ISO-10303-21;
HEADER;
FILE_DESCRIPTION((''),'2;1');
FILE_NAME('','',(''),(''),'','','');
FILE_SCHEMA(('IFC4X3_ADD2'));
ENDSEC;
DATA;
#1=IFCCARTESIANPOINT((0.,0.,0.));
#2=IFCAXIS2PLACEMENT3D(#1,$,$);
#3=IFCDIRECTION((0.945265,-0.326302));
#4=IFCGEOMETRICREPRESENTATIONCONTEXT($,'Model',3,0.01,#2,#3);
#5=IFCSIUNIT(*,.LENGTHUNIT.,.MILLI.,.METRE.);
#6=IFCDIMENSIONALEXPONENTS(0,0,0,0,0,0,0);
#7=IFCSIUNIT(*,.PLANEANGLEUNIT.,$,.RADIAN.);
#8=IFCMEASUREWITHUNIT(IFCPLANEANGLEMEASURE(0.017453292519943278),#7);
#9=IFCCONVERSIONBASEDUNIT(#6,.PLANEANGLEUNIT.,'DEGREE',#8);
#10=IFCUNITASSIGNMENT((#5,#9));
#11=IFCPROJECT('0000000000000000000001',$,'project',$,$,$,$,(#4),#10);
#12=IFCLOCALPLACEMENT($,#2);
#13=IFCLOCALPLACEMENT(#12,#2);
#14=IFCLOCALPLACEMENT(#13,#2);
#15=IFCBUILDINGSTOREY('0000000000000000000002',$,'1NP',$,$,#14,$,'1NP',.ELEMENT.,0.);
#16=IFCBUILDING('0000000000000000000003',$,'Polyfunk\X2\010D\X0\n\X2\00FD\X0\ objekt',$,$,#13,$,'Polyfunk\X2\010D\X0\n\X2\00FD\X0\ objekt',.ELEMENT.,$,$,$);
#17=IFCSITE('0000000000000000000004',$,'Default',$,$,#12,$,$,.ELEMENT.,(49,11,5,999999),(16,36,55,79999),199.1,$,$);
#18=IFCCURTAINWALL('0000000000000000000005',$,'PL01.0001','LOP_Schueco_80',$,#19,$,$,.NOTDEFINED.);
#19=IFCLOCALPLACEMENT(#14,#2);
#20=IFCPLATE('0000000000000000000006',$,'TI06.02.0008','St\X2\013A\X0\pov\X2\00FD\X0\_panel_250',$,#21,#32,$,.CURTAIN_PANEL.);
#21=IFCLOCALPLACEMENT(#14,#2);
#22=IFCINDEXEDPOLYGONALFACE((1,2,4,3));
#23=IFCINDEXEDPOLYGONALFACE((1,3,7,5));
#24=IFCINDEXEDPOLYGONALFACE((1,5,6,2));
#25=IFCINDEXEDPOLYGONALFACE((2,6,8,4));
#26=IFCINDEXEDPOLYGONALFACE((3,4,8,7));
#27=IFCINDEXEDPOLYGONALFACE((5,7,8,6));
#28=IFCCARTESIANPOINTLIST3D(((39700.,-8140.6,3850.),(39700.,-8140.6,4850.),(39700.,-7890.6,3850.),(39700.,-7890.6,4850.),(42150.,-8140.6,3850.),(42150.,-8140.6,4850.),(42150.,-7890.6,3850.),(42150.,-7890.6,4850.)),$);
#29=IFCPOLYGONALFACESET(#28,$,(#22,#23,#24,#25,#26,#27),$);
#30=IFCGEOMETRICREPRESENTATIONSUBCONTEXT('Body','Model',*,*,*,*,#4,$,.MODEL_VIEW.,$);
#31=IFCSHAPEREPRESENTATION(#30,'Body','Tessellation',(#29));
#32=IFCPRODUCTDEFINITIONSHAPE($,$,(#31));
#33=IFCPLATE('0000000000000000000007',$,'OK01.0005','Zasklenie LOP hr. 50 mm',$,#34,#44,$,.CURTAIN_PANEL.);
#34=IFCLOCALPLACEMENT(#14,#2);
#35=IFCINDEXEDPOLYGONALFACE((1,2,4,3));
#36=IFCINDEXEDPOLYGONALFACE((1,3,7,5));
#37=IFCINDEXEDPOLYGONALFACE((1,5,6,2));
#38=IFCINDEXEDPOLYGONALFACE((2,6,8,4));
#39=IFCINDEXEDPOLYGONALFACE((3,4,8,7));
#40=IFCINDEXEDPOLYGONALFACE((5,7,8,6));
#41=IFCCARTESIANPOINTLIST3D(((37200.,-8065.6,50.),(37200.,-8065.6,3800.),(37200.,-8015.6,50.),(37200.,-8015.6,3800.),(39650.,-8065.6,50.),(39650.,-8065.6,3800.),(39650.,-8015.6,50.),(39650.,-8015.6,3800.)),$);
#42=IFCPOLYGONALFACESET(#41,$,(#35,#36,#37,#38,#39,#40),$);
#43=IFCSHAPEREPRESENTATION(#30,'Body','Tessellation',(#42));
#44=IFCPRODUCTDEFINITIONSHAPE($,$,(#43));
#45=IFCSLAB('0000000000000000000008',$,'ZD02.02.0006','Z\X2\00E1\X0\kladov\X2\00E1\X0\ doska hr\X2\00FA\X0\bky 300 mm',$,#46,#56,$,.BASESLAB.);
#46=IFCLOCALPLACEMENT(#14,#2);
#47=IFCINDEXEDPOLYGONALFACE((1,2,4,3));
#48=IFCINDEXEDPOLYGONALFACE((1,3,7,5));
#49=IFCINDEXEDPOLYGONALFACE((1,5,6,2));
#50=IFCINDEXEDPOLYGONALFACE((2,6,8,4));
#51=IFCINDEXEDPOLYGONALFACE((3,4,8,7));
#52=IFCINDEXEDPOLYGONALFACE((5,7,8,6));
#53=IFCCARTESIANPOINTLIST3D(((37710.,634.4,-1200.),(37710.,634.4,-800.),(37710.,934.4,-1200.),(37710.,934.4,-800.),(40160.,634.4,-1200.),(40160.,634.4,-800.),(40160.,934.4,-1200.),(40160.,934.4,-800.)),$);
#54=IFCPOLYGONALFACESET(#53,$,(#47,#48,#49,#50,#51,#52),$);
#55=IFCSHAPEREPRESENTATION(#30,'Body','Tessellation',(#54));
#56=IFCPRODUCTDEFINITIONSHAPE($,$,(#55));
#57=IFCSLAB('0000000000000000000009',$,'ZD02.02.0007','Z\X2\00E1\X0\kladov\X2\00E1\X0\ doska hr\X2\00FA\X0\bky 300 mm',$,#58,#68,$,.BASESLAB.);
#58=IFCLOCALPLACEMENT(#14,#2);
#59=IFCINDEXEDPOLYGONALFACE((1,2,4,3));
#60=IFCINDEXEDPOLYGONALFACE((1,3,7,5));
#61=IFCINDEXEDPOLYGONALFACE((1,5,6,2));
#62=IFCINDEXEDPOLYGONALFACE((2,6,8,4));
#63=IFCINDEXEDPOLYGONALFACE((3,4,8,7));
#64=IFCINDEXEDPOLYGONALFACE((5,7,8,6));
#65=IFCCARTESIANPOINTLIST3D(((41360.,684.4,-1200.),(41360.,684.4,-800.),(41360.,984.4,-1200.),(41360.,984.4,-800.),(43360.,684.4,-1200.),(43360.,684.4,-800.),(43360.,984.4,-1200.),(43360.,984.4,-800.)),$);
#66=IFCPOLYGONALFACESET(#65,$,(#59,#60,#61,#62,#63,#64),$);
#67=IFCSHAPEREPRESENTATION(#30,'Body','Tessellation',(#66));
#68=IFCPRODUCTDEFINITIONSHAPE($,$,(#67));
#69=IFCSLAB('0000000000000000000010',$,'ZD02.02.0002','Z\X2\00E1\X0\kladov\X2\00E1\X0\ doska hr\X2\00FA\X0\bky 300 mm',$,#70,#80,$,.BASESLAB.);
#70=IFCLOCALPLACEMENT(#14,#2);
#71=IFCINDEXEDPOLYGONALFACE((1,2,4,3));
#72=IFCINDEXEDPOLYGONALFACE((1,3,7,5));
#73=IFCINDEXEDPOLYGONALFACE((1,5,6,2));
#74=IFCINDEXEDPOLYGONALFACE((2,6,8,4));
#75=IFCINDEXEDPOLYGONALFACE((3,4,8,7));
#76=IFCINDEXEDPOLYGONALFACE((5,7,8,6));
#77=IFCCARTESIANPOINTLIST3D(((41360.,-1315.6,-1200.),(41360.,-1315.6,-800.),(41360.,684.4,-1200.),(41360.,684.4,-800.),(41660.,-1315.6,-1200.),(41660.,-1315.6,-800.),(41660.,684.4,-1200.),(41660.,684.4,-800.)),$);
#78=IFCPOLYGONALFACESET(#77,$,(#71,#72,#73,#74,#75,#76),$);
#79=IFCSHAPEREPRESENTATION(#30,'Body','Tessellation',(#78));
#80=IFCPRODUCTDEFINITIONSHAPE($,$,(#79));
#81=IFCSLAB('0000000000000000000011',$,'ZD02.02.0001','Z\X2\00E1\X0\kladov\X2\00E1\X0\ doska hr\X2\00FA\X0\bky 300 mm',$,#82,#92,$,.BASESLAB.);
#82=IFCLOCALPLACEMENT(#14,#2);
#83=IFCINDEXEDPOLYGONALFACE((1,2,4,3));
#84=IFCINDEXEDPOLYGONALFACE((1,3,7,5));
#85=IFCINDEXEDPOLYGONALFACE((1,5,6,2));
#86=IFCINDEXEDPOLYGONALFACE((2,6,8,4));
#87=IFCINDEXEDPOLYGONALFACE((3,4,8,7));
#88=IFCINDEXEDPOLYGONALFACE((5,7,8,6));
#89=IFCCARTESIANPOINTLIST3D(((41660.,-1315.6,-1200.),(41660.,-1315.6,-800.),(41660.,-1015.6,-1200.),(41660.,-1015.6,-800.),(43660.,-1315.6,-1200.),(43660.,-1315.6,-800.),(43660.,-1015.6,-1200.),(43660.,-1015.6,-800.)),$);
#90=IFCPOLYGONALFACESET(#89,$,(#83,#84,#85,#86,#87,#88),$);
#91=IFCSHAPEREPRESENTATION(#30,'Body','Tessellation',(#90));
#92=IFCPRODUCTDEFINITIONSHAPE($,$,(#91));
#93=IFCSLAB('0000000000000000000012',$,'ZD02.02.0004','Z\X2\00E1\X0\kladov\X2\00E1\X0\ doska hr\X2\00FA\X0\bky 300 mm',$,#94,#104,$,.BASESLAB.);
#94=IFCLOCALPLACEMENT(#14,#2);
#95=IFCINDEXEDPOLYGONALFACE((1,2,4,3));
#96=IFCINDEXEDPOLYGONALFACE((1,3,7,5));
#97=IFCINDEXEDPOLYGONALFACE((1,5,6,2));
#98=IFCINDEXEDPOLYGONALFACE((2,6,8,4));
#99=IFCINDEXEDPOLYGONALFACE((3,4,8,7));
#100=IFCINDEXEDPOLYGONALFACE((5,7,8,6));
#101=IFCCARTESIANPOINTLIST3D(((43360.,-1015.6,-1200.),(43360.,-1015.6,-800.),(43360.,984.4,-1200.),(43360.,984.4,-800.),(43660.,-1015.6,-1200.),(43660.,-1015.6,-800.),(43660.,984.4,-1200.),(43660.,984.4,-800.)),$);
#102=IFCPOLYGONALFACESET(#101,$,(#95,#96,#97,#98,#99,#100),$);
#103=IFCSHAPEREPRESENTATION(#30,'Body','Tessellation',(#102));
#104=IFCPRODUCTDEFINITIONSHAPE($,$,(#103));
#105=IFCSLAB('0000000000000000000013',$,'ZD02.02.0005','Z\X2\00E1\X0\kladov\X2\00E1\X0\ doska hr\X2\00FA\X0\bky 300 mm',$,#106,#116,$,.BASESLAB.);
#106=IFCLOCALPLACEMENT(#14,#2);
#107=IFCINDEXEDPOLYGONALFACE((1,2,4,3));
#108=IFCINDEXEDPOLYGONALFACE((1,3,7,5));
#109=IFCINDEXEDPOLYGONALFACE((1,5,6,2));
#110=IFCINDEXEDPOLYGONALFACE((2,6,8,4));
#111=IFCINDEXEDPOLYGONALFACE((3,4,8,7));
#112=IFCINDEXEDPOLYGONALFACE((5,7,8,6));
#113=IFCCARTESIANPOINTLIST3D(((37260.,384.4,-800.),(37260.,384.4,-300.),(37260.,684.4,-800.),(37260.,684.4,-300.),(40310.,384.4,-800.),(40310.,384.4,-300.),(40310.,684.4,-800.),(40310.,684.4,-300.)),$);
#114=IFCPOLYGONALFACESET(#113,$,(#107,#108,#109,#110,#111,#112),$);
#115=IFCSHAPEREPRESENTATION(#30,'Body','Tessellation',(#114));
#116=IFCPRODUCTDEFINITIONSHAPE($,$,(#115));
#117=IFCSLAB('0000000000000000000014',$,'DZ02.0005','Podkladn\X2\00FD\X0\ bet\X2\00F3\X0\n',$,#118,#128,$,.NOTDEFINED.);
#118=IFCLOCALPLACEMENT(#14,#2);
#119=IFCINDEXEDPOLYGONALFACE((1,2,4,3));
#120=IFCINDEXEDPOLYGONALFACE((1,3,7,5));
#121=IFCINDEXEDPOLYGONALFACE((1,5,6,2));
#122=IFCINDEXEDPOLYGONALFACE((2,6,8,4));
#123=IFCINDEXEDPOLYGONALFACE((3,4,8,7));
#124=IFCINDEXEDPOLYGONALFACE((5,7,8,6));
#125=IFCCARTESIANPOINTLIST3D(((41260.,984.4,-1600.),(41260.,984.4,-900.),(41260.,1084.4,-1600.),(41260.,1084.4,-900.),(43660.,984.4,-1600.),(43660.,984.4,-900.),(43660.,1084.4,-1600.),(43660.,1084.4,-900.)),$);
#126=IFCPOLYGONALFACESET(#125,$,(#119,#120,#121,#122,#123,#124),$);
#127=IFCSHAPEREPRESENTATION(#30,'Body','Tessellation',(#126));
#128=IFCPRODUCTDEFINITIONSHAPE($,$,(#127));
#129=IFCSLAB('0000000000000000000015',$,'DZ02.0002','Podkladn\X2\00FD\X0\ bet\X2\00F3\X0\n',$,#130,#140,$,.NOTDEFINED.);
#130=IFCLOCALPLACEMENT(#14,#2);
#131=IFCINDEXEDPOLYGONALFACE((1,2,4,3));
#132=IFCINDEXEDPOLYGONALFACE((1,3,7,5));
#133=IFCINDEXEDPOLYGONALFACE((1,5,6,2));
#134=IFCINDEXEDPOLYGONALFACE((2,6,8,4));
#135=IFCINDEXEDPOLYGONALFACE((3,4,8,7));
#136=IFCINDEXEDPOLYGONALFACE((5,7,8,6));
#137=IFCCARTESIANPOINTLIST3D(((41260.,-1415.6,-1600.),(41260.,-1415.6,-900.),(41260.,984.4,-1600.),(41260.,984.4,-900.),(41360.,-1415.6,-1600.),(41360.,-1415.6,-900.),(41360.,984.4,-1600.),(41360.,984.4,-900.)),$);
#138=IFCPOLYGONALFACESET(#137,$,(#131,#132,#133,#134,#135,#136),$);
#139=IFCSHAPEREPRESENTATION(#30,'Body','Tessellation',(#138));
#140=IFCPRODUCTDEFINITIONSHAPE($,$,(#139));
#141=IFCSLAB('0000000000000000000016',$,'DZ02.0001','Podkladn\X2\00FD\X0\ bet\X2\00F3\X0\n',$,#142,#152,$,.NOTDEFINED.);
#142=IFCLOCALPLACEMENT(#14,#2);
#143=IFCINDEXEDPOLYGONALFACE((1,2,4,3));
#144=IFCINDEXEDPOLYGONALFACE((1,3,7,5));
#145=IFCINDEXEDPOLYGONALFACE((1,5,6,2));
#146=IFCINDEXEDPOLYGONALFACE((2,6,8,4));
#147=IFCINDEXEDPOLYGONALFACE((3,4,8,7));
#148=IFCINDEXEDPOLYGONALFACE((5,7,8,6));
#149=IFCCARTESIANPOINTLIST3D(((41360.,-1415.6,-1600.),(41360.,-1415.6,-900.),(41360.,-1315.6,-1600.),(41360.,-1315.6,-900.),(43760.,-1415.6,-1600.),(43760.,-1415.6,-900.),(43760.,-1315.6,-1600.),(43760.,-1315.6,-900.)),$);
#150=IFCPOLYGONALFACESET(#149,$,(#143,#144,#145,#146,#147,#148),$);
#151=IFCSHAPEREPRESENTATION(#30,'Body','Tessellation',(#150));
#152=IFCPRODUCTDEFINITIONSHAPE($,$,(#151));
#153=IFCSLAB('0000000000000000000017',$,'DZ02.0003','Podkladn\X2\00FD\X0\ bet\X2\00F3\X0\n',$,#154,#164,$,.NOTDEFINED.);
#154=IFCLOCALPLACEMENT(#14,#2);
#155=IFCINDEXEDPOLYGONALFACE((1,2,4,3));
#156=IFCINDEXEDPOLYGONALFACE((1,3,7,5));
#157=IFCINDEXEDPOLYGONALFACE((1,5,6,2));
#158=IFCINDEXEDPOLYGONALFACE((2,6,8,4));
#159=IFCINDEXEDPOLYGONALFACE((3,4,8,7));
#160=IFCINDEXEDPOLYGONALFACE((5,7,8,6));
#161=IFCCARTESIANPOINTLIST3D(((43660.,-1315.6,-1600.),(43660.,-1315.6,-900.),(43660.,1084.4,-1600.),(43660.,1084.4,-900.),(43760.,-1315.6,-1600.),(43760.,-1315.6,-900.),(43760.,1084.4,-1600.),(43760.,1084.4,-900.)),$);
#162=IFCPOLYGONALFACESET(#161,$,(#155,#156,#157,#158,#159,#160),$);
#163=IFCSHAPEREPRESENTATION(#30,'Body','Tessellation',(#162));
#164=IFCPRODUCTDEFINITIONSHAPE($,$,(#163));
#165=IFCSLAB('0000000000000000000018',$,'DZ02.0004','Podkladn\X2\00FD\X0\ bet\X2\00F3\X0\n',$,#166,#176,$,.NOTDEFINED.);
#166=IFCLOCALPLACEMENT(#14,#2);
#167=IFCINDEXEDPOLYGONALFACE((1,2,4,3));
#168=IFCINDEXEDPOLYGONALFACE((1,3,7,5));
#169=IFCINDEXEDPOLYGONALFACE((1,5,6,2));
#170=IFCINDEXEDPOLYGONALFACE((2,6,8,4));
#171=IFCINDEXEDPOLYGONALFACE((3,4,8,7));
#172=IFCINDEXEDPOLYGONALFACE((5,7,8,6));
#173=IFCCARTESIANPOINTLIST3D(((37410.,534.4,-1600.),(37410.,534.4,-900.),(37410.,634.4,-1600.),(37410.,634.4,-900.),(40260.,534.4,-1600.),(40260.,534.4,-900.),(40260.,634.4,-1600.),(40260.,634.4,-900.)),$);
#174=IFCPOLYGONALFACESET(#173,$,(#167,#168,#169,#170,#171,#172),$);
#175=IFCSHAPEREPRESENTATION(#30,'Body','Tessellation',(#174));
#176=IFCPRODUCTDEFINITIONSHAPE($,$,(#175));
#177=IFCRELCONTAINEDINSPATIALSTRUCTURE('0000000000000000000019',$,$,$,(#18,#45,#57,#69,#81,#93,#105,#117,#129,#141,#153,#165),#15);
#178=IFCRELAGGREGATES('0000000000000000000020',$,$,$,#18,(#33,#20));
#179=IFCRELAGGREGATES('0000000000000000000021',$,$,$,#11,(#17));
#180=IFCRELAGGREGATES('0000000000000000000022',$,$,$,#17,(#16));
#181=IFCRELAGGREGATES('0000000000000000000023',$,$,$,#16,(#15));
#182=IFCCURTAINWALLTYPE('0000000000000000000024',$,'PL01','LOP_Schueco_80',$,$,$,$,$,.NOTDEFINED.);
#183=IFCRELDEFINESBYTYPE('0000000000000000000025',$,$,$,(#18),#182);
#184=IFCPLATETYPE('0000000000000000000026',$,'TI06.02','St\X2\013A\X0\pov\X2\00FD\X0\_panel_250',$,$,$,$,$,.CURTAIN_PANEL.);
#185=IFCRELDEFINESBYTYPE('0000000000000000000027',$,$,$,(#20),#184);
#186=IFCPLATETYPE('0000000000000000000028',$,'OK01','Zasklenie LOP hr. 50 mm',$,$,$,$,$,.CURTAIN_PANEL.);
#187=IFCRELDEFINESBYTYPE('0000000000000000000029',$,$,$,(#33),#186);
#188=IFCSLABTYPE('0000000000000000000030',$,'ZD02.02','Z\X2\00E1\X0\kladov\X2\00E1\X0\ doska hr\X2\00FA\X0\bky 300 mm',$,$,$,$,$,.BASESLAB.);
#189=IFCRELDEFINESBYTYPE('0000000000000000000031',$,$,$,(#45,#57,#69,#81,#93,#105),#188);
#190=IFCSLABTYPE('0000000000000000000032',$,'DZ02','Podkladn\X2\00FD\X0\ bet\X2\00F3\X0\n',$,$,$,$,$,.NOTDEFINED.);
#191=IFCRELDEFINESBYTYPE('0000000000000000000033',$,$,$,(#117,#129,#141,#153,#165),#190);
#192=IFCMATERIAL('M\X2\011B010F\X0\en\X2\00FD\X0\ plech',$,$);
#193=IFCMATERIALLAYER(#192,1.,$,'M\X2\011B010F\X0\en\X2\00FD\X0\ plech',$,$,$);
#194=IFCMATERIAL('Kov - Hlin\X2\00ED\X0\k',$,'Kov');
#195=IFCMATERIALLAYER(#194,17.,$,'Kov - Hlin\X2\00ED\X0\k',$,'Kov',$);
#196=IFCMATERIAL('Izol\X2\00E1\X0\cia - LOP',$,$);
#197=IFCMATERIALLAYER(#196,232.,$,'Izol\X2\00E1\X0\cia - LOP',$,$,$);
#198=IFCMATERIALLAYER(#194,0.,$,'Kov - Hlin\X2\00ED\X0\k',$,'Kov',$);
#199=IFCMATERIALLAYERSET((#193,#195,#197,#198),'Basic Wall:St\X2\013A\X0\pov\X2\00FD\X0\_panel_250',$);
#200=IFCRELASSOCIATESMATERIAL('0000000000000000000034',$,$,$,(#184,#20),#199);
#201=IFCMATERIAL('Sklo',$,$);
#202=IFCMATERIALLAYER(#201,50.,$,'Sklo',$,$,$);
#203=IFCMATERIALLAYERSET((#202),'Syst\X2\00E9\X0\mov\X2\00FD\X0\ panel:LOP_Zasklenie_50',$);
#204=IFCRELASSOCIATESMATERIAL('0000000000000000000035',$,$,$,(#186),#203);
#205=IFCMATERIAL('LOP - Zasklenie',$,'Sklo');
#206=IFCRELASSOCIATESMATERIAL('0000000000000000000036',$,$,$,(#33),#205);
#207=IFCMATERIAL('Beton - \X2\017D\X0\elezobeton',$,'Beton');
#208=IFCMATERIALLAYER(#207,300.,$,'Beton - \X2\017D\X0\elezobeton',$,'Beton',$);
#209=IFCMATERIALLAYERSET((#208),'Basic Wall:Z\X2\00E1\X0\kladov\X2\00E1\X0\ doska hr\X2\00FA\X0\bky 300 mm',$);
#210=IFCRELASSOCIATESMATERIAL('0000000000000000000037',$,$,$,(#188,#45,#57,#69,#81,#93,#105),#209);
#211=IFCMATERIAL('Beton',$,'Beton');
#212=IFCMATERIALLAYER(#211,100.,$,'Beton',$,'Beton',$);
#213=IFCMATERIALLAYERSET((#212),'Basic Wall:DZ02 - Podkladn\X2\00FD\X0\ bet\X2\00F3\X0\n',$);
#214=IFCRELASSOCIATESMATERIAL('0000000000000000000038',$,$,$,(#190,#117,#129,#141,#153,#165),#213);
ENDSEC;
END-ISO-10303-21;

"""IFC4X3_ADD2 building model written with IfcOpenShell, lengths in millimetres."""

from ifc_helpers import new_model, entity, si_unit, converted_unit, direction, frame, frame_2d, origin, place, context, subcontext, project, spatial, rectangle, extrude, source, transform, mapped, material, layer, layer_set, layer_usage, type_object, type_shapes, element, aggregate, save


model = new_model("IFC4X3_ADD2")

# Units and contexts
model_context = context("Model", 3, precision=0.01, world=origin(), true_north=direction((0.945265, -0.326302)))
body_context = subcontext(model_context, "Body", "Model", "MODEL_VIEW")
ifc_project = project(units=[si_unit("LENGTHUNIT", "METRE", prefix="MILLI"), converted_unit("PLANEANGLEUNIT", "DEGREE", entity("IfcPlaneAngleMeasure", 0.017453292519943278), si_unit("PLANEANGLEUNIT", "RADIAN"), dimensions=[0, 0, 0, 0, 0, 0, 0])], contexts=[model_context])

# Site, building, storey
site_placement = place(None, origin())
site = spatial("IfcSite", under=ifc_project, at=site_placement, Name="Default", CompositionType="ELEMENT", RefLatitude=(49, 11, 5, 999999), RefLongitude=(16, 36, 55, 79999), RefElevation=199.1)
building_placement = place(site_placement, origin())
building = spatial("IfcBuilding", under=site, at=building_placement, Name="Polyfunkčný objekt", LongName="Polyfunkčný objekt", CompositionType="ELEMENT")
storey_placement = place(building_placement, origin())
storey = spatial("IfcBuildingStorey", under=building, at=storey_placement, Name="1NP", LongName="1NP", CompositionType="ELEMENT", Elevation=0.0)

# Curtain wall, plates
curtain_wall_type = type_object("IfcCurtainWallType", Name="PL01", Description="LOP_Schueco_80", PredefinedType="NOTDEFINED")
curtain_wall_placement = place(storey_placement, origin())
curtain_wall = element("IfcCurtainWall", 1, at=curtain_wall_placement, inside=storey, type_object=curtain_wall_type, Name="PL01.0001", Description="LOP_Schueco_80", PredefinedType="NOTDEFINED")
ifc_material_1 = material(Name="Měďený plech")
ifc_layer_1 = layer(ifc_material_1, 1.0, Name="Měďený plech")
ifc_material_2 = material(Name="Kov - Hliník", Category="Kov")
ifc_layer_2 = layer(ifc_material_2, 17.0, Name="Kov - Hliník", Category="Kov")
ifc_material_3 = material(Name="Izolácia - LOP")
ifc_layer_3 = layer(ifc_material_3, 232.0, Name="Izolácia - LOP")
ifc_layer_4 = layer(ifc_material_2, 0.0, Name="Kov - Hliník", Category="Kov")
ifc_layer_set_1 = layer_set([ifc_layer_1, ifc_layer_2, ifc_layer_3, ifc_layer_4], Name="Basic Wall:Stĺpový_panel_250")
ifc_layer_usage = layer_usage(ifc_layer_set_1, "AXIS2", "POSITIVE", -125.0)
plate_type_1 = type_object("IfcPlateType", Name="TI06.02", Description="Stĺpový_panel_250", PredefinedType="CURTAIN_PANEL", material=ifc_layer_set_1)
plate_1_placement = place(storey_placement, frame((39700.0, -8015.6, 3850.0)))
plate_1 = element("IfcPlate", 2, at=plate_1_placement, type_object=plate_type_1, material=ifc_layer_usage, Name="TI06.02.0008", Description="Stĺpový_panel_250", PredefinedType="CURTAIN_PANEL", context=body_context, shape_type="SweptSolid", body=[
    extrude(rectangle(XDim=250.0, YDim=2450.0, at=frame_2d((0.0, 0.0), x_axis=(1.0, 0.0))), frame((1225.0, 0.0, 0.0), z_axis=(0.0, 0.0, 1.0), x_axis=(0.0, 1.0, 0.0)), (0.0, 0.0, 1.0), 1000.0),
])
ifc_material_4 = material(Name="LOP - Zasklenie", Category="Sklo")
ifc_material_5 = material(Name="Sklo")
ifc_layer_5 = layer(ifc_material_5, 50.0, Name="Sklo")
ifc_layer_set_2 = layer_set([ifc_layer_5], Name="Systémový panel:LOP_Zasklenie_50")
plate_type_2 = type_object("IfcPlateType", Name="OK01", Description="Zasklenie LOP hr. 50 mm", PredefinedType="CURTAIN_PANEL", material=ifc_layer_set_2)
shared_shape_1 = source(origin(), body_context, "Body", "SweptSolid", [
    extrude(rectangle(XDim=3750.0, YDim=2450.0, at=frame_2d((-331.2, 0.0), x_axis=(1.0, 0.0))), frame((0.0, -50.0, 2206.2), z_axis=(0.0, 1.0, 0.0), x_axis=(0.0, 0.0, 1.0)), (0.0, 0.0, 1.0), 50.0),
])
type_shapes(plate_type_2, [shared_shape_1])
plate_2_placement = place(curtain_wall_placement, frame((38425.0, -8015.6, 50.0)))
plate_2 = element("IfcPlate", 3, at=plate_2_placement, type_object=plate_type_2, material=ifc_material_4, Name="OK01.0005", Description="Zasklenie LOP hr. 50 mm", PredefinedType="CURTAIN_PANEL", context=body_context, shape_type="MappedRepresentation", body=[
    mapped(shared_shape_1, transform((0.0, 0.0, 0.0), scale=1.0)),
])
aggregate(curtain_wall, [plate_2, plate_1])

# Slabs
ifc_material_6 = material(Name="Beton - Železobeton", Category="Beton")
ifc_layer_6 = layer(ifc_material_6, 300.0, Name="Beton - Železobeton", Category="Beton")
ifc_layer_set_3 = layer_set([ifc_layer_6], Name="Basic Wall:Základová doska hrúbky 300 mm")
slab_type_1 = type_object("IfcSlabType", Name="ZD02.02", Description="Základová doska hrúbky 300 mm", PredefinedType="BASESLAB", material=ifc_layer_set_3)
slab_1_placement = place(storey_placement, frame((40160.0, 784.4, -1200.0), z_axis=(0.0, 0.0, 1.0), x_axis=(-1.0, 0.0, 0.0)))
element("IfcSlab", 4, at=slab_1_placement, inside=storey, type_object=slab_type_1, material=ifc_layer_set_3, Name="ZD02.02.0006", Description="Základová doska hrúbky 300 mm", PredefinedType="BASESLAB", context=body_context, shape_type="SweptSolid", body=[
    extrude(rectangle(XDim=2450.0, YDim=300.0, at=frame_2d((1225.0, 0.0), x_axis=(-1.0, 0.0))), origin(), (0.0, 0.0, 1.0), 400.0),
])
slab_2_placement = place(storey_placement, frame((41360.0, 834.4, -1200.0)))
element("IfcSlab", 5, at=slab_2_placement, inside=storey, type_object=slab_type_1, material=ifc_layer_set_3, Name="ZD02.02.0007", Description="Základová doska hrúbky 300 mm", PredefinedType="BASESLAB", context=body_context, shape_type="SweptSolid", body=[
    extrude(rectangle(XDim=2000.0, YDim=300.0, at=frame_2d((1000.0, 0.0), x_axis=(-1.0, 0.0))), origin(), (0.0, 0.0, 1.0), 400.0),
])
slab_3_placement = place(storey_placement, frame((41510.0, -1315.6, -1200.0), z_axis=(0.0, 0.0, 1.0), x_axis=(0.0, 1.0, 0.0)))
element("IfcSlab", 6, at=slab_3_placement, inside=storey, type_object=slab_type_1, material=ifc_layer_set_3, Name="ZD02.02.0002", Description="Základová doska hrúbky 300 mm", PredefinedType="BASESLAB", context=body_context, shape_type="SweptSolid", body=[
    extrude(rectangle(XDim=2000.0, YDim=300.0, at=frame_2d((1000.0, 0.0), x_axis=(-1.0, 0.0))), origin(), (0.0, 0.0, 1.0), 400.0),
])
slab_4_placement = place(storey_placement, frame((43660.0, -1165.6, -1200.0), z_axis=(0.0, 0.0, 1.0), x_axis=(-1.0, 0.0, 0.0)))
element("IfcSlab", 7, at=slab_4_placement, inside=storey, type_object=slab_type_1, material=ifc_layer_set_3, Name="ZD02.02.0001", Description="Základová doska hrúbky 300 mm", PredefinedType="BASESLAB", context=body_context, shape_type="SweptSolid", body=[
    extrude(rectangle(XDim=2000.0, YDim=300.0, at=frame_2d((1000.0, 0.0), x_axis=(-1.0, 0.0))), origin(), (0.0, 0.0, 1.0), 400.0),
])
slab_5_placement = place(storey_placement, frame((43510.0, 984.4, -1200.0), z_axis=(0.0, 0.0, 1.0), x_axis=(0.0, -1.0, 0.0)))
element("IfcSlab", 8, at=slab_5_placement, inside=storey, type_object=slab_type_1, material=ifc_layer_set_3, Name="ZD02.02.0004", Description="Základová doska hrúbky 300 mm", PredefinedType="BASESLAB", context=body_context, shape_type="SweptSolid", body=[
    extrude(rectangle(XDim=2000.0, YDim=300.0, at=frame_2d((1000.0, 0.0), x_axis=(-1.0, 0.0))), origin(), (0.0, 0.0, 1.0), 400.0),
])
slab_6_placement = place(storey_placement, frame((40310.0, 534.4, -800.0), z_axis=(0.0, 0.0, 1.0), x_axis=(-1.0, 0.0, 0.0)))
element("IfcSlab", 9, at=slab_6_placement, inside=storey, type_object=slab_type_1, material=ifc_layer_set_3, Name="ZD02.02.0005", Description="Základová doska hrúbky 300 mm", PredefinedType="BASESLAB", context=body_context, shape_type="SweptSolid", body=[
    extrude(rectangle(XDim=3050.0, YDim=300.0, at=frame_2d((1525.0, 0.0), x_axis=(-1.0, 0.0))), origin(), (0.0, 0.0, 1.0), 500.0),
])
ifc_material_7 = material(Name="Beton", Category="Beton")
ifc_layer_7 = layer(ifc_material_7, 100.0, Name="Beton", Category="Beton")
ifc_layer_set_4 = layer_set([ifc_layer_7], Name="Basic Wall:DZ02 - Podkladný betón")
slab_type_2 = type_object("IfcSlabType", Name="DZ02", Description="Podkladný betón", PredefinedType="NOTDEFINED", material=ifc_layer_set_4)
slab_7_placement = place(storey_placement, frame((41260.0, 1034.4, -1600.0)))
element("IfcSlab", 10, at=slab_7_placement, inside=storey, type_object=slab_type_2, material=ifc_layer_set_4, Name="DZ02.0005", Description="Podkladný betón", PredefinedType="NOTDEFINED", context=body_context, shape_type="SweptSolid", body=[
    extrude(rectangle(XDim=2400.0, YDim=100.0, at=frame_2d((1200.0, 0.0), x_axis=(-1.0, 0.0))), origin(), (0.0, 0.0, 1.0), 700.0),
])
slab_8_placement = place(storey_placement, frame((41310.0, -1415.6, -1600.0), z_axis=(0.0, 0.0, 1.0), x_axis=(0.0, 1.0, 0.0)))
element("IfcSlab", 11, at=slab_8_placement, inside=storey, type_object=slab_type_2, material=ifc_layer_set_4, Name="DZ02.0002", Description="Podkladný betón", PredefinedType="NOTDEFINED", context=body_context, shape_type="SweptSolid", body=[
    extrude(rectangle(XDim=2400.0, YDim=100.0, at=frame_2d((1200.0, 0.0), x_axis=(-1.0, 0.0))), origin(), (0.0, 0.0, 1.0), 700.0),
])
slab_9_placement = place(storey_placement, frame((43760.0, -1365.6, -1600.0), z_axis=(0.0, 0.0, 1.0), x_axis=(-1.0, 0.0, 0.0)))
element("IfcSlab", 12, at=slab_9_placement, inside=storey, type_object=slab_type_2, material=ifc_layer_set_4, Name="DZ02.0001", Description="Podkladný betón", PredefinedType="NOTDEFINED", context=body_context, shape_type="SweptSolid", body=[
    extrude(rectangle(XDim=2400.0, YDim=100.0, at=frame_2d((1200.0, 0.0), x_axis=(-1.0, 0.0))), origin(), (0.0, 0.0, 1.0), 700.0),
])
slab_10_placement = place(storey_placement, frame((43710.0, 1084.4, -1600.0), z_axis=(0.0, 0.0, 1.0), x_axis=(0.0, -1.0, 0.0)))
element("IfcSlab", 13, at=slab_10_placement, inside=storey, type_object=slab_type_2, material=ifc_layer_set_4, Name="DZ02.0003", Description="Podkladný betón", PredefinedType="NOTDEFINED", context=body_context, shape_type="SweptSolid", body=[
    extrude(rectangle(XDim=2400.0, YDim=100.0, at=frame_2d((1200.0, 0.0), x_axis=(-1.0, 0.0))), origin(), (0.0, 0.0, 1.0), 700.0),
])
slab_11_placement = place(storey_placement, frame((40260.0, 584.4, -1600.0), z_axis=(0.0, 0.0, 1.0), x_axis=(-1.0, 0.0, 0.0)))
element("IfcSlab", 14, at=slab_11_placement, inside=storey, type_object=slab_type_2, material=ifc_layer_set_4, Name="DZ02.0004", Description="Podkladný betón", PredefinedType="NOTDEFINED", context=body_context, shape_type="SweptSolid", body=[
    extrude(rectangle(XDim=2850.0, YDim=100.0, at=frame_2d((1425.0, 0.0), x_axis=(-1.0, 0.0))), origin(), (0.0, 0.0, 1.0), 700.0),
])

save(model, "model.ifc")
